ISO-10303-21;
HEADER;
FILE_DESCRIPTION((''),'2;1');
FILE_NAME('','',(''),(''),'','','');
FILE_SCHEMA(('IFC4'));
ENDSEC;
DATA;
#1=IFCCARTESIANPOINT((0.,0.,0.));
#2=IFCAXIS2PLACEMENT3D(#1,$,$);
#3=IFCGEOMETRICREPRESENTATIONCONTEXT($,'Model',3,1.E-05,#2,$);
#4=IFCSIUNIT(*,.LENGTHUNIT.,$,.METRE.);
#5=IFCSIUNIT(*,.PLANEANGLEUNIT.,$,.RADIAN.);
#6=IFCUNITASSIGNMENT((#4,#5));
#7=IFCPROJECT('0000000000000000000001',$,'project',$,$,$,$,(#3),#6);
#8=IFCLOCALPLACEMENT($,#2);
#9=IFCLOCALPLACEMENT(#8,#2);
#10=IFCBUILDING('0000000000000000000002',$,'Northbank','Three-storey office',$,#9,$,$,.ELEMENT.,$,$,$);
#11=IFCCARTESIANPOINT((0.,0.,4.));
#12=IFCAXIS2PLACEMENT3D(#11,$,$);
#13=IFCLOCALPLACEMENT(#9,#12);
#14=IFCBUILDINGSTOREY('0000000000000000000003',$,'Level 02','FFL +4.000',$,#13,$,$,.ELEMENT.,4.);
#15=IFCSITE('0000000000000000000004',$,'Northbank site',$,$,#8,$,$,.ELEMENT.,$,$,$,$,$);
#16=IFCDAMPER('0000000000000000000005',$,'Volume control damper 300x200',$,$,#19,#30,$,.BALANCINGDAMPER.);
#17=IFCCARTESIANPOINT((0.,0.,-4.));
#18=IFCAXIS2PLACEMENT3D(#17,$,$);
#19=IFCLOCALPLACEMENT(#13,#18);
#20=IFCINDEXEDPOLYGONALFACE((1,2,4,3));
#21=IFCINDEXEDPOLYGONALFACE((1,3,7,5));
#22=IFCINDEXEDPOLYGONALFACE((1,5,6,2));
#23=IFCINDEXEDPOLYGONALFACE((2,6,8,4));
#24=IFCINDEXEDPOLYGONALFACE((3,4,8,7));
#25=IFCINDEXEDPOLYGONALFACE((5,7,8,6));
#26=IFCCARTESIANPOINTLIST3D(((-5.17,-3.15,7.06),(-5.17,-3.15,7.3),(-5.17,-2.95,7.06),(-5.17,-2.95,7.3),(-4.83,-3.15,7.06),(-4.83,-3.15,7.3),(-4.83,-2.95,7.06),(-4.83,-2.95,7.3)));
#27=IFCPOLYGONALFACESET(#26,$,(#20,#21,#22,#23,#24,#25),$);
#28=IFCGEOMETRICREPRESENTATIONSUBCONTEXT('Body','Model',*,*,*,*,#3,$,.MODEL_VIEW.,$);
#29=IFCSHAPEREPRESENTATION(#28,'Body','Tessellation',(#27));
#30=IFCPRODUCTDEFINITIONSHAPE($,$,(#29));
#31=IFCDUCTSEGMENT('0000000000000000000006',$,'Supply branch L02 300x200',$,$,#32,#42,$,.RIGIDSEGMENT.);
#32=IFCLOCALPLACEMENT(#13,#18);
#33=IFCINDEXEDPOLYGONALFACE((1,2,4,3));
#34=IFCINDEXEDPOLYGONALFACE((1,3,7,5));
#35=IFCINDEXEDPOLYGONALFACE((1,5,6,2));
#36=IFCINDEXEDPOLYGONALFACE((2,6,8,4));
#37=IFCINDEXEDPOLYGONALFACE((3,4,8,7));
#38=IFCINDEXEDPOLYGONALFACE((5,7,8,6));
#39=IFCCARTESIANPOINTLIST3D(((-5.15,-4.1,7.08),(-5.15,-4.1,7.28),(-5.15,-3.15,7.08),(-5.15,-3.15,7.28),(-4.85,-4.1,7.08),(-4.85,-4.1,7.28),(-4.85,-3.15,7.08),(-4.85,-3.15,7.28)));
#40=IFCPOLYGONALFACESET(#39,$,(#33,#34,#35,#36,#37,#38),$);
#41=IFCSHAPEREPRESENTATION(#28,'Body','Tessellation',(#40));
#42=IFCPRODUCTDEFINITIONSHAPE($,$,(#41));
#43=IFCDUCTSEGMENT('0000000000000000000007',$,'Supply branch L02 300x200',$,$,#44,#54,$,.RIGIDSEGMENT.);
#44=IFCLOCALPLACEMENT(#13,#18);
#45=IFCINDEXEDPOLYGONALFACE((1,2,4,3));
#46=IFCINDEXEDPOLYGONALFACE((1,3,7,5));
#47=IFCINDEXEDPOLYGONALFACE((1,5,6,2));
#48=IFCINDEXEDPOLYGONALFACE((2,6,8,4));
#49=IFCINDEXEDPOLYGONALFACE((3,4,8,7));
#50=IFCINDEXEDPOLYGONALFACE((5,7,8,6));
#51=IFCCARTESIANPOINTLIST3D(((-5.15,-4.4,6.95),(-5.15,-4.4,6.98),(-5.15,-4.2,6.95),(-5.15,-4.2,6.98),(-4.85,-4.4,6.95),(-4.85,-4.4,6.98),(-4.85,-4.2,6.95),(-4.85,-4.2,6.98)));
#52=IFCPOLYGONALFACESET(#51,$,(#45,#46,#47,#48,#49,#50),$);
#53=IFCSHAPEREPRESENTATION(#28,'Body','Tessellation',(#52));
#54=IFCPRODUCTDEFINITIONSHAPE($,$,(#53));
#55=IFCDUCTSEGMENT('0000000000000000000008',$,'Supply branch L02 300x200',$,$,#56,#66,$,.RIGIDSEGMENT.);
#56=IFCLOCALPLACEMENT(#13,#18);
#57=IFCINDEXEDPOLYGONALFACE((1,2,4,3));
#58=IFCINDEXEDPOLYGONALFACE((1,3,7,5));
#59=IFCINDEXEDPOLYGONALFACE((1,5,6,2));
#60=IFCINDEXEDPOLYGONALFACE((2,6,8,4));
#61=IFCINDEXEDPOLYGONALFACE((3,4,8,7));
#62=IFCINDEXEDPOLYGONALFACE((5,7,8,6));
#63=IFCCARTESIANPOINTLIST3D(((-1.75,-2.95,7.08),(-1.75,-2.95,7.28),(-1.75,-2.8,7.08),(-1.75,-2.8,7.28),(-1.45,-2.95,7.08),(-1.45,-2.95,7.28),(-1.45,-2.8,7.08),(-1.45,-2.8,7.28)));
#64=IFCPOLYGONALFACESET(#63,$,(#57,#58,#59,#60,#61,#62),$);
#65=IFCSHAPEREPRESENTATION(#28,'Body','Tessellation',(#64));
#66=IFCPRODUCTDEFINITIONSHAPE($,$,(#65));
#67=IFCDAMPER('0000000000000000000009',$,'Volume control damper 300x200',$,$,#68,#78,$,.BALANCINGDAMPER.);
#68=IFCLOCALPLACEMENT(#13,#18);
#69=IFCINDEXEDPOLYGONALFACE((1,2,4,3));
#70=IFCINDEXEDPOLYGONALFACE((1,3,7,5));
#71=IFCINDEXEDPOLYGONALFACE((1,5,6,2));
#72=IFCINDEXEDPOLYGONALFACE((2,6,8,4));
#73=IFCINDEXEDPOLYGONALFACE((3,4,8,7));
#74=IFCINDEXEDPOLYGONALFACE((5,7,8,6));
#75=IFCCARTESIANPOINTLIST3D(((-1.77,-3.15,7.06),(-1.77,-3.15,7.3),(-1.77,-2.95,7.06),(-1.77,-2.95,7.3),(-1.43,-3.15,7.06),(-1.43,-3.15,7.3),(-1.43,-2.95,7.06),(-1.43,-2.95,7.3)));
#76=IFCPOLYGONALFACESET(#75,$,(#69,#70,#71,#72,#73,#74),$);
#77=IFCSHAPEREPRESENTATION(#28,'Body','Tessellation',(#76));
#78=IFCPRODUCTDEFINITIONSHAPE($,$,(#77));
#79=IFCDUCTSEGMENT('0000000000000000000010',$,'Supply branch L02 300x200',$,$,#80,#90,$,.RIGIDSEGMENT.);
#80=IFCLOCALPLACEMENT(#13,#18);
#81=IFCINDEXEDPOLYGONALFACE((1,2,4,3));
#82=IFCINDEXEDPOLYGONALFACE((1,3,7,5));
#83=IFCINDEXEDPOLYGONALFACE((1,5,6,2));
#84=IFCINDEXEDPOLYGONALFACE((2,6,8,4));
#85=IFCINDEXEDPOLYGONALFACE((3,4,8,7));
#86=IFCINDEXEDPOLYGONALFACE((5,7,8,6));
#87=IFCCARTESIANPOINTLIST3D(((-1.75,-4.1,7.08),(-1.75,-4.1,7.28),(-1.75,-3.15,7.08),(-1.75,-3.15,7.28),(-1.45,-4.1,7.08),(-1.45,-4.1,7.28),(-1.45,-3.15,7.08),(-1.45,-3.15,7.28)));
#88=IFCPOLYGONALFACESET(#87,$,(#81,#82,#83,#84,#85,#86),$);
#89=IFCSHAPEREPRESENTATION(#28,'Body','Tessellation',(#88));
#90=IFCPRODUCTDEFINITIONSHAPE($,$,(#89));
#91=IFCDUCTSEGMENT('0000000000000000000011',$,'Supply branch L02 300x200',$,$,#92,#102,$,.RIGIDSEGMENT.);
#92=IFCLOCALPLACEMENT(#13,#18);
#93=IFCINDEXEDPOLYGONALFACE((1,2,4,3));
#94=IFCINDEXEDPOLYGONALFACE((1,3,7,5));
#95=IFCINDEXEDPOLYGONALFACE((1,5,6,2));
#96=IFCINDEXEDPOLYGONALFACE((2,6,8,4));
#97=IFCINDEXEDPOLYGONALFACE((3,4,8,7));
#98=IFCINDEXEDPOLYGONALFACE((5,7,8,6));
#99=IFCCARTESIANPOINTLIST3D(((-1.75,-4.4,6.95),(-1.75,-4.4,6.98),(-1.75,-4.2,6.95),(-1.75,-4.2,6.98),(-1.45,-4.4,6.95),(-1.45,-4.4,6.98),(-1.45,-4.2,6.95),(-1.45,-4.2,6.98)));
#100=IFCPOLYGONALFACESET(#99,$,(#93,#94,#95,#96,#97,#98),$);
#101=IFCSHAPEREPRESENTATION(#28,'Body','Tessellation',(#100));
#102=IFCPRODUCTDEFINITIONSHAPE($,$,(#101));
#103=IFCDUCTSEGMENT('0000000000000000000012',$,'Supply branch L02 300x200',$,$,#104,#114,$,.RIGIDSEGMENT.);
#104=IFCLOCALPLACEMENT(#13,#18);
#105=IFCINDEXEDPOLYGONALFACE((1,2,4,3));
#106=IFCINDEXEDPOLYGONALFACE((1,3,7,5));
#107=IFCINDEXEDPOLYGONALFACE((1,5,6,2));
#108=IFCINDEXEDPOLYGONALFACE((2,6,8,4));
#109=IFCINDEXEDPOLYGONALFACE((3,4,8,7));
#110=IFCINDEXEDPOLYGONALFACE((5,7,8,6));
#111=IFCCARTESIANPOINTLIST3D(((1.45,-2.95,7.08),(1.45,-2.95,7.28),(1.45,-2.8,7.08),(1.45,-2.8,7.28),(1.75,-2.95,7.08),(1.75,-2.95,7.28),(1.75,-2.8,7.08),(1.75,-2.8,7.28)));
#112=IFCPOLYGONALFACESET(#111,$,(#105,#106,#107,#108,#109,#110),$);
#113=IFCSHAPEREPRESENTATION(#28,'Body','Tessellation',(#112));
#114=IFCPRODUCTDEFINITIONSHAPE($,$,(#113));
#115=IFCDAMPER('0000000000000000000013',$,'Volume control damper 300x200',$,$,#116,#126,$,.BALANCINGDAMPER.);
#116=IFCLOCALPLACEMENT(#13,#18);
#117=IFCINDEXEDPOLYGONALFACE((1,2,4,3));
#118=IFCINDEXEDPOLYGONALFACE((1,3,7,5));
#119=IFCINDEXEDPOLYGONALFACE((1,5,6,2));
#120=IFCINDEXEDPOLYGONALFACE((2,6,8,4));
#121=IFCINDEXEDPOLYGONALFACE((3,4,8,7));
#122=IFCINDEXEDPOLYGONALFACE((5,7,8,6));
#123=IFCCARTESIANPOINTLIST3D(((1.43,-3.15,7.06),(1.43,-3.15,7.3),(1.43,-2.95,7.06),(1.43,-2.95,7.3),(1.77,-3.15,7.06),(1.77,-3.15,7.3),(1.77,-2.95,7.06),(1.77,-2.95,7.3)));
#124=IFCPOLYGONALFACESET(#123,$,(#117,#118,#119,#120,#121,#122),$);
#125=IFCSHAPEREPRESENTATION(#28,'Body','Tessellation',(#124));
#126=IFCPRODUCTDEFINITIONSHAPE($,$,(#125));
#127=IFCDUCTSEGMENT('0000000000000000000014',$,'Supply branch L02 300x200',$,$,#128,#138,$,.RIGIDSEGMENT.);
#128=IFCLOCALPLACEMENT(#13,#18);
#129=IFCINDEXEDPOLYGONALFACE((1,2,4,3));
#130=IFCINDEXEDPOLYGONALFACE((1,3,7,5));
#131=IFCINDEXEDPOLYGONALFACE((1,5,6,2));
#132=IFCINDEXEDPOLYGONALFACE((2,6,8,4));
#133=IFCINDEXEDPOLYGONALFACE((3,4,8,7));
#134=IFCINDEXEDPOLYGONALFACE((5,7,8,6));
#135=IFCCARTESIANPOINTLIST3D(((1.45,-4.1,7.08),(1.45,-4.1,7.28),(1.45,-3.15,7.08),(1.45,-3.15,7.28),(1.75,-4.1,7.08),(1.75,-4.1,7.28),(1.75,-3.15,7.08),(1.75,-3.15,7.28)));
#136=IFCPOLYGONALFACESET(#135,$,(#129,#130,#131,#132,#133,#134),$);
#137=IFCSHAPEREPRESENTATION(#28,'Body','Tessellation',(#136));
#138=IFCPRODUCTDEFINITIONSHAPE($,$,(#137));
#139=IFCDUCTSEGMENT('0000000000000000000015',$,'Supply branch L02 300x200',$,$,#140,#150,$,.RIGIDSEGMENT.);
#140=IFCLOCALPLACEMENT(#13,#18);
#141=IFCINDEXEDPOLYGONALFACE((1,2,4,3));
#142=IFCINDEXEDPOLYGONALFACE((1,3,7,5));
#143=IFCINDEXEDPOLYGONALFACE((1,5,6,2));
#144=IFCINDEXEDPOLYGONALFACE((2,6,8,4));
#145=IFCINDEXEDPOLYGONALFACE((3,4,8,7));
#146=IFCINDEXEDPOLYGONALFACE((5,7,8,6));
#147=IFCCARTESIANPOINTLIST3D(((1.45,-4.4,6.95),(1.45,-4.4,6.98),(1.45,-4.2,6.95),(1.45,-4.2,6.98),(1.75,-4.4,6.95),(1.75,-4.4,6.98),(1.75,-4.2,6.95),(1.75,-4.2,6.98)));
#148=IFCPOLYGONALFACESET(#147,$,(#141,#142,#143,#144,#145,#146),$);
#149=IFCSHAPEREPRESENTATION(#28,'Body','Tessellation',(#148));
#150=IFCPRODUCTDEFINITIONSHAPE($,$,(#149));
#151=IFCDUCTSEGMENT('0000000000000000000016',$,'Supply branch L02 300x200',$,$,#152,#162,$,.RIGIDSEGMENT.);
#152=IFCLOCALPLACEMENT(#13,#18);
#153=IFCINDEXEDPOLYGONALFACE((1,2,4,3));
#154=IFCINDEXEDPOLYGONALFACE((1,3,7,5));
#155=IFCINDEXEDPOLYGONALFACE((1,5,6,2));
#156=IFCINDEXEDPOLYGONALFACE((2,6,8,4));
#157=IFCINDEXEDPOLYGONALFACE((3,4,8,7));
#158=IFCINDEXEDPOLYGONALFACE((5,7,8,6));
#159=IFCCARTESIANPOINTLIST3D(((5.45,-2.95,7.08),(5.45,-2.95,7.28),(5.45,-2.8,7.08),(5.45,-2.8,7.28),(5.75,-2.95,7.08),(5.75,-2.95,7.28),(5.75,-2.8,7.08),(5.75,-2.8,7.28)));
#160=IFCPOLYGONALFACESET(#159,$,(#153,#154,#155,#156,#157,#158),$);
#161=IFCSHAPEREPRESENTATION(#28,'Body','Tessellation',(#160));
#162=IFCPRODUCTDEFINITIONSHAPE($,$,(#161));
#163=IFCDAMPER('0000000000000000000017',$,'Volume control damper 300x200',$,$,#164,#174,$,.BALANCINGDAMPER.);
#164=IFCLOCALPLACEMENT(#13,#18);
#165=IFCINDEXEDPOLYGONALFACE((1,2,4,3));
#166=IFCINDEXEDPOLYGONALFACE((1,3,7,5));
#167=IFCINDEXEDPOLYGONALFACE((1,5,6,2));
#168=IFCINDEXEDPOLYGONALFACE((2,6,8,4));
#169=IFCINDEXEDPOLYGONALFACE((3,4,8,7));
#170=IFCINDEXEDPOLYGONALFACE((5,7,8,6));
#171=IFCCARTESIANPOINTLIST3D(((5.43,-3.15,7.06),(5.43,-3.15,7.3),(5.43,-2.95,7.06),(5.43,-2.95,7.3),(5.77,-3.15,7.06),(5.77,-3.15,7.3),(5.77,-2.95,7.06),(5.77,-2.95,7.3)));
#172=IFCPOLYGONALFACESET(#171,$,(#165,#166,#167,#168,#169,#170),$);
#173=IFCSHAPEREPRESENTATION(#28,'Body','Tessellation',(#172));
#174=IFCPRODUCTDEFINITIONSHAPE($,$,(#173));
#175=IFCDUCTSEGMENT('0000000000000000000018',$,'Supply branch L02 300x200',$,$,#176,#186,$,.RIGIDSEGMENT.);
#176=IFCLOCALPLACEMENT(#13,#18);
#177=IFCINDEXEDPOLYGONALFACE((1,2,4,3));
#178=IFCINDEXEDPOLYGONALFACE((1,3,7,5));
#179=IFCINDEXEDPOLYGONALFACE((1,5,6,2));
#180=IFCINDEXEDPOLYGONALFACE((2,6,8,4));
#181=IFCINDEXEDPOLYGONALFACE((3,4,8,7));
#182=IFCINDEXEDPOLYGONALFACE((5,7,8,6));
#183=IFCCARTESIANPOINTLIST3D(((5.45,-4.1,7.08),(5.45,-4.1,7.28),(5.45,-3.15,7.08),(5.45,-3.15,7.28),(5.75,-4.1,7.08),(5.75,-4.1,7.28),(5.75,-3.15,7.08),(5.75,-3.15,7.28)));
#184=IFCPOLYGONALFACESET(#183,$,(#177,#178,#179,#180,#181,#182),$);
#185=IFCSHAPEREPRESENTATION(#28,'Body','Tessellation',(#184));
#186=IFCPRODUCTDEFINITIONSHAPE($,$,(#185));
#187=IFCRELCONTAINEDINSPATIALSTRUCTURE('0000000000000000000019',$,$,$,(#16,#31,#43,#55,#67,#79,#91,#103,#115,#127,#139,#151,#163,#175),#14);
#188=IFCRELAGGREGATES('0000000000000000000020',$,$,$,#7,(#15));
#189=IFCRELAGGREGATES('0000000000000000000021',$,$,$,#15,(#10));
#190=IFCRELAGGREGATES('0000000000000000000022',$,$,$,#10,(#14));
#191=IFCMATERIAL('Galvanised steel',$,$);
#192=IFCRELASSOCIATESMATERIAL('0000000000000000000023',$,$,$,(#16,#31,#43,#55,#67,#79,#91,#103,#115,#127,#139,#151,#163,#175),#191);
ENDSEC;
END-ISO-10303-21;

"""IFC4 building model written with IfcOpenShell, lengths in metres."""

from ifc_helpers import new_model, si_unit, frame, origin, place, context, subcontext, project, spatial, rectangle, extrude, material, element, save


model = new_model("IFC4")

# Units and contexts
model_context = context("Model", 3, precision=1e-05, world=origin())
body_context = subcontext(model_context, "Body", "Model", "MODEL_VIEW")
ifc_project = project(units=[si_unit("LENGTHUNIT", "METRE"), si_unit("PLANEANGLEUNIT", "RADIAN")], contexts=[model_context])

# Site, building, storey
site_placement = place(None, origin())
site = spatial("IfcSite", under=ifc_project, at=site_placement, Name="Northbank site", CompositionType="ELEMENT")
building_placement = place(site_placement, origin())
building = spatial("IfcBuilding", under=site, at=building_placement, Name="Northbank", Description="Three-storey office", CompositionType="ELEMENT")
storey_placement = place(building_placement, frame((0.0, 0.0, 4.0)))
storey = spatial("IfcBuildingStorey", under=building, at=storey_placement, Name="Level 02", Description="FFL +4.000", CompositionType="ELEMENT", Elevation=4.0)

# Damper
ifc_material_1 = material(Name="Galvanised steel")
damper_1_placement = place(storey_placement, frame((0.0, 0.0, -4.0)))
element("IfcDamper", 1, at=damper_1_placement, inside=storey, material=ifc_material_1, Name="Volume control damper 300x200", PredefinedType="BALANCINGDAMPER", context=body_context, shape_type="SweptSolid", body=[
    extrude(rectangle(XDim=0.34, YDim=0.24), frame((-5.0, -2.95, 7.18), z_axis=(0.0, -1.0, 0.0), x_axis=(1.0, 0.0, 0.0)), (0.0, 0.0, 1.0), 0.2),
])

# Duct segments
duct_segment_1_placement = place(storey_placement, frame((0.0, 0.0, -4.0)))
element("IfcDuctSegment", 2, at=duct_segment_1_placement, inside=storey, material=ifc_material_1, Name="Supply branch L02 300x200", PredefinedType="RIGIDSEGMENT", context=body_context, shape_type="SweptSolid", body=[
    extrude(rectangle(XDim=0.3, YDim=0.2), frame((-5.0, -3.15, 7.18), z_axis=(0.0, -1.0, 0.0), x_axis=(1.0, 0.0, 0.0)), (0.0, 0.0, 1.0), 0.95),
])
duct_segment_2_placement = place(storey_placement, frame((0.0, 0.0, -4.0)))
element("IfcDuctSegment", 3, at=duct_segment_2_placement, inside=storey, material=ifc_material_1, Name="Supply branch L02 300x200", PredefinedType="RIGIDSEGMENT", context=body_context, shape_type="SweptSolid", body=[
    extrude(rectangle(XDim=0.3, YDim=0.2), frame((-5.0, -4.3, 6.98), z_axis=(0.0, 0.0, -1.0), x_axis=(1.0, 0.0, 0.0)), (0.0, 0.0, 1.0), 0.03),
])

# Duct segment
duct_segment_3_placement = place(storey_placement, frame((0.0, 0.0, -4.0)))
element("IfcDuctSegment", 4, at=duct_segment_3_placement, inside=storey, material=ifc_material_1, Name="Supply branch L02 300x200", PredefinedType="RIGIDSEGMENT", context=body_context, shape_type="SweptSolid", body=[
    extrude(rectangle(XDim=0.3, YDim=0.2), frame((-1.6, -2.8, 7.18), z_axis=(0.0, -1.0, 0.0), x_axis=(1.0, 0.0, 0.0)), (0.0, 0.0, 1.0), 0.15),
])

# Damper
damper_2_placement = place(storey_placement, frame((0.0, 0.0, -4.0)))
element("IfcDamper", 5, at=damper_2_placement, inside=storey, material=ifc_material_1, Name="Volume control damper 300x200", PredefinedType="BALANCINGDAMPER", context=body_context, shape_type="SweptSolid", body=[
    extrude(rectangle(XDim=0.34, YDim=0.24), frame((-1.6, -2.95, 7.18), z_axis=(0.0, -1.0, 0.0), x_axis=(1.0, 0.0, 0.0)), (0.0, 0.0, 1.0), 0.2),
])

# Duct segments
duct_segment_4_placement = place(storey_placement, frame((0.0, 0.0, -4.0)))
element("IfcDuctSegment", 6, at=duct_segment_4_placement, inside=storey, material=ifc_material_1, Name="Supply branch L02 300x200", PredefinedType="RIGIDSEGMENT", context=body_context, shape_type="SweptSolid", body=[
    extrude(rectangle(XDim=0.3, YDim=0.2), frame((-1.6, -3.15, 7.18), z_axis=(0.0, -1.0, 0.0), x_axis=(1.0, 0.0, 0.0)), (0.0, 0.0, 1.0), 0.95),
])
duct_segment_5_placement = place(storey_placement, frame((0.0, 0.0, -4.0)))
element("IfcDuctSegment", 7, at=duct_segment_5_placement, inside=storey, material=ifc_material_1, Name="Supply branch L02 300x200", PredefinedType="RIGIDSEGMENT", context=body_context, shape_type="SweptSolid", body=[
    extrude(rectangle(XDim=0.3, YDim=0.2), frame((-1.6, -4.3, 6.98), z_axis=(0.0, 0.0, -1.0), x_axis=(1.0, 0.0, 0.0)), (0.0, 0.0, 1.0), 0.03),
])

# Duct segment
duct_segment_6_placement = place(storey_placement, frame((0.0, 0.0, -4.0)))
element("IfcDuctSegment", 8, at=duct_segment_6_placement, inside=storey, material=ifc_material_1, Name="Supply branch L02 300x200", PredefinedType="RIGIDSEGMENT", context=body_context, shape_type="SweptSolid", body=[
    extrude(rectangle(XDim=0.3, YDim=0.2), frame((1.6, -2.8, 7.18), z_axis=(0.0, -1.0, 0.0), x_axis=(1.0, 0.0, 0.0)), (0.0, 0.0, 1.0), 0.15),
])

# Damper
damper_3_placement = place(storey_placement, frame((0.0, 0.0, -4.0)))
element("IfcDamper", 9, at=damper_3_placement, inside=storey, material=ifc_material_1, Name="Volume control damper 300x200", PredefinedType="BALANCINGDAMPER", context=body_context, shape_type="SweptSolid", body=[
    extrude(rectangle(XDim=0.34, YDim=0.24), frame((1.6, -2.95, 7.18), z_axis=(0.0, -1.0, 0.0), x_axis=(1.0, 0.0, 0.0)), (0.0, 0.0, 1.0), 0.2),
])

# Duct segments
duct_segment_7_placement = place(storey_placement, frame((0.0, 0.0, -4.0)))
element("IfcDuctSegment", 10, at=duct_segment_7_placement, inside=storey, material=ifc_material_1, Name="Supply branch L02 300x200", PredefinedType="RIGIDSEGMENT", context=body_context, shape_type="SweptSolid", body=[
    extrude(rectangle(XDim=0.3, YDim=0.2), frame((1.6, -3.15, 7.18), z_axis=(0.0, -1.0, 0.0), x_axis=(1.0, 0.0, 0.0)), (0.0, 0.0, 1.0), 0.95),
])
duct_segment_8_placement = place(storey_placement, frame((0.0, 0.0, -4.0)))
element("IfcDuctSegment", 11, at=duct_segment_8_placement, inside=storey, material=ifc_material_1, Name="Supply branch L02 300x200", PredefinedType="RIGIDSEGMENT", context=body_context, shape_type="SweptSolid", body=[
    extrude(rectangle(XDim=0.3, YDim=0.2), frame((1.6, -4.3, 6.98), z_axis=(0.0, 0.0, -1.0), x_axis=(1.0, 0.0, 0.0)), (0.0, 0.0, 1.0), 0.03),
])

# Duct segment
duct_segment_9_placement = place(storey_placement, frame((0.0, 0.0, -4.0)))
element("IfcDuctSegment", 12, at=duct_segment_9_placement, inside=storey, material=ifc_material_1, Name="Supply branch L02 300x200", PredefinedType="RIGIDSEGMENT", context=body_context, shape_type="SweptSolid", body=[
    extrude(rectangle(XDim=0.3, YDim=0.2), frame((5.6, -2.8, 7.18), z_axis=(0.0, -1.0, 0.0), x_axis=(1.0, 0.0, 0.0)), (0.0, 0.0, 1.0), 0.15),
])

# Damper
damper_4_placement = place(storey_placement, frame((0.0, 0.0, -4.0)))
element("IfcDamper", 13, at=damper_4_placement, inside=storey, material=ifc_material_1, Name="Volume control damper 300x200", PredefinedType="BALANCINGDAMPER", context=body_context, shape_type="SweptSolid", body=[
    extrude(rectangle(XDim=0.34, YDim=0.24), frame((5.6, -2.95, 7.18), z_axis=(0.0, -1.0, 0.0), x_axis=(1.0, 0.0, 0.0)), (0.0, 0.0, 1.0), 0.2),
])

# Duct segment
duct_segment_10_placement = place(storey_placement, frame((0.0, 0.0, -4.0)))
element("IfcDuctSegment", 14, at=duct_segment_10_placement, inside=storey, material=ifc_material_1, Name="Supply branch L02 300x200", PredefinedType="RIGIDSEGMENT", context=body_context, shape_type="SweptSolid", body=[
    extrude(rectangle(XDim=0.3, YDim=0.2), frame((5.6, -3.15, 7.18), z_axis=(0.0, -1.0, 0.0), x_axis=(1.0, 0.0, 0.0)), (0.0, 0.0, 1.0), 0.95),
])

save(model, "model.ifc")
